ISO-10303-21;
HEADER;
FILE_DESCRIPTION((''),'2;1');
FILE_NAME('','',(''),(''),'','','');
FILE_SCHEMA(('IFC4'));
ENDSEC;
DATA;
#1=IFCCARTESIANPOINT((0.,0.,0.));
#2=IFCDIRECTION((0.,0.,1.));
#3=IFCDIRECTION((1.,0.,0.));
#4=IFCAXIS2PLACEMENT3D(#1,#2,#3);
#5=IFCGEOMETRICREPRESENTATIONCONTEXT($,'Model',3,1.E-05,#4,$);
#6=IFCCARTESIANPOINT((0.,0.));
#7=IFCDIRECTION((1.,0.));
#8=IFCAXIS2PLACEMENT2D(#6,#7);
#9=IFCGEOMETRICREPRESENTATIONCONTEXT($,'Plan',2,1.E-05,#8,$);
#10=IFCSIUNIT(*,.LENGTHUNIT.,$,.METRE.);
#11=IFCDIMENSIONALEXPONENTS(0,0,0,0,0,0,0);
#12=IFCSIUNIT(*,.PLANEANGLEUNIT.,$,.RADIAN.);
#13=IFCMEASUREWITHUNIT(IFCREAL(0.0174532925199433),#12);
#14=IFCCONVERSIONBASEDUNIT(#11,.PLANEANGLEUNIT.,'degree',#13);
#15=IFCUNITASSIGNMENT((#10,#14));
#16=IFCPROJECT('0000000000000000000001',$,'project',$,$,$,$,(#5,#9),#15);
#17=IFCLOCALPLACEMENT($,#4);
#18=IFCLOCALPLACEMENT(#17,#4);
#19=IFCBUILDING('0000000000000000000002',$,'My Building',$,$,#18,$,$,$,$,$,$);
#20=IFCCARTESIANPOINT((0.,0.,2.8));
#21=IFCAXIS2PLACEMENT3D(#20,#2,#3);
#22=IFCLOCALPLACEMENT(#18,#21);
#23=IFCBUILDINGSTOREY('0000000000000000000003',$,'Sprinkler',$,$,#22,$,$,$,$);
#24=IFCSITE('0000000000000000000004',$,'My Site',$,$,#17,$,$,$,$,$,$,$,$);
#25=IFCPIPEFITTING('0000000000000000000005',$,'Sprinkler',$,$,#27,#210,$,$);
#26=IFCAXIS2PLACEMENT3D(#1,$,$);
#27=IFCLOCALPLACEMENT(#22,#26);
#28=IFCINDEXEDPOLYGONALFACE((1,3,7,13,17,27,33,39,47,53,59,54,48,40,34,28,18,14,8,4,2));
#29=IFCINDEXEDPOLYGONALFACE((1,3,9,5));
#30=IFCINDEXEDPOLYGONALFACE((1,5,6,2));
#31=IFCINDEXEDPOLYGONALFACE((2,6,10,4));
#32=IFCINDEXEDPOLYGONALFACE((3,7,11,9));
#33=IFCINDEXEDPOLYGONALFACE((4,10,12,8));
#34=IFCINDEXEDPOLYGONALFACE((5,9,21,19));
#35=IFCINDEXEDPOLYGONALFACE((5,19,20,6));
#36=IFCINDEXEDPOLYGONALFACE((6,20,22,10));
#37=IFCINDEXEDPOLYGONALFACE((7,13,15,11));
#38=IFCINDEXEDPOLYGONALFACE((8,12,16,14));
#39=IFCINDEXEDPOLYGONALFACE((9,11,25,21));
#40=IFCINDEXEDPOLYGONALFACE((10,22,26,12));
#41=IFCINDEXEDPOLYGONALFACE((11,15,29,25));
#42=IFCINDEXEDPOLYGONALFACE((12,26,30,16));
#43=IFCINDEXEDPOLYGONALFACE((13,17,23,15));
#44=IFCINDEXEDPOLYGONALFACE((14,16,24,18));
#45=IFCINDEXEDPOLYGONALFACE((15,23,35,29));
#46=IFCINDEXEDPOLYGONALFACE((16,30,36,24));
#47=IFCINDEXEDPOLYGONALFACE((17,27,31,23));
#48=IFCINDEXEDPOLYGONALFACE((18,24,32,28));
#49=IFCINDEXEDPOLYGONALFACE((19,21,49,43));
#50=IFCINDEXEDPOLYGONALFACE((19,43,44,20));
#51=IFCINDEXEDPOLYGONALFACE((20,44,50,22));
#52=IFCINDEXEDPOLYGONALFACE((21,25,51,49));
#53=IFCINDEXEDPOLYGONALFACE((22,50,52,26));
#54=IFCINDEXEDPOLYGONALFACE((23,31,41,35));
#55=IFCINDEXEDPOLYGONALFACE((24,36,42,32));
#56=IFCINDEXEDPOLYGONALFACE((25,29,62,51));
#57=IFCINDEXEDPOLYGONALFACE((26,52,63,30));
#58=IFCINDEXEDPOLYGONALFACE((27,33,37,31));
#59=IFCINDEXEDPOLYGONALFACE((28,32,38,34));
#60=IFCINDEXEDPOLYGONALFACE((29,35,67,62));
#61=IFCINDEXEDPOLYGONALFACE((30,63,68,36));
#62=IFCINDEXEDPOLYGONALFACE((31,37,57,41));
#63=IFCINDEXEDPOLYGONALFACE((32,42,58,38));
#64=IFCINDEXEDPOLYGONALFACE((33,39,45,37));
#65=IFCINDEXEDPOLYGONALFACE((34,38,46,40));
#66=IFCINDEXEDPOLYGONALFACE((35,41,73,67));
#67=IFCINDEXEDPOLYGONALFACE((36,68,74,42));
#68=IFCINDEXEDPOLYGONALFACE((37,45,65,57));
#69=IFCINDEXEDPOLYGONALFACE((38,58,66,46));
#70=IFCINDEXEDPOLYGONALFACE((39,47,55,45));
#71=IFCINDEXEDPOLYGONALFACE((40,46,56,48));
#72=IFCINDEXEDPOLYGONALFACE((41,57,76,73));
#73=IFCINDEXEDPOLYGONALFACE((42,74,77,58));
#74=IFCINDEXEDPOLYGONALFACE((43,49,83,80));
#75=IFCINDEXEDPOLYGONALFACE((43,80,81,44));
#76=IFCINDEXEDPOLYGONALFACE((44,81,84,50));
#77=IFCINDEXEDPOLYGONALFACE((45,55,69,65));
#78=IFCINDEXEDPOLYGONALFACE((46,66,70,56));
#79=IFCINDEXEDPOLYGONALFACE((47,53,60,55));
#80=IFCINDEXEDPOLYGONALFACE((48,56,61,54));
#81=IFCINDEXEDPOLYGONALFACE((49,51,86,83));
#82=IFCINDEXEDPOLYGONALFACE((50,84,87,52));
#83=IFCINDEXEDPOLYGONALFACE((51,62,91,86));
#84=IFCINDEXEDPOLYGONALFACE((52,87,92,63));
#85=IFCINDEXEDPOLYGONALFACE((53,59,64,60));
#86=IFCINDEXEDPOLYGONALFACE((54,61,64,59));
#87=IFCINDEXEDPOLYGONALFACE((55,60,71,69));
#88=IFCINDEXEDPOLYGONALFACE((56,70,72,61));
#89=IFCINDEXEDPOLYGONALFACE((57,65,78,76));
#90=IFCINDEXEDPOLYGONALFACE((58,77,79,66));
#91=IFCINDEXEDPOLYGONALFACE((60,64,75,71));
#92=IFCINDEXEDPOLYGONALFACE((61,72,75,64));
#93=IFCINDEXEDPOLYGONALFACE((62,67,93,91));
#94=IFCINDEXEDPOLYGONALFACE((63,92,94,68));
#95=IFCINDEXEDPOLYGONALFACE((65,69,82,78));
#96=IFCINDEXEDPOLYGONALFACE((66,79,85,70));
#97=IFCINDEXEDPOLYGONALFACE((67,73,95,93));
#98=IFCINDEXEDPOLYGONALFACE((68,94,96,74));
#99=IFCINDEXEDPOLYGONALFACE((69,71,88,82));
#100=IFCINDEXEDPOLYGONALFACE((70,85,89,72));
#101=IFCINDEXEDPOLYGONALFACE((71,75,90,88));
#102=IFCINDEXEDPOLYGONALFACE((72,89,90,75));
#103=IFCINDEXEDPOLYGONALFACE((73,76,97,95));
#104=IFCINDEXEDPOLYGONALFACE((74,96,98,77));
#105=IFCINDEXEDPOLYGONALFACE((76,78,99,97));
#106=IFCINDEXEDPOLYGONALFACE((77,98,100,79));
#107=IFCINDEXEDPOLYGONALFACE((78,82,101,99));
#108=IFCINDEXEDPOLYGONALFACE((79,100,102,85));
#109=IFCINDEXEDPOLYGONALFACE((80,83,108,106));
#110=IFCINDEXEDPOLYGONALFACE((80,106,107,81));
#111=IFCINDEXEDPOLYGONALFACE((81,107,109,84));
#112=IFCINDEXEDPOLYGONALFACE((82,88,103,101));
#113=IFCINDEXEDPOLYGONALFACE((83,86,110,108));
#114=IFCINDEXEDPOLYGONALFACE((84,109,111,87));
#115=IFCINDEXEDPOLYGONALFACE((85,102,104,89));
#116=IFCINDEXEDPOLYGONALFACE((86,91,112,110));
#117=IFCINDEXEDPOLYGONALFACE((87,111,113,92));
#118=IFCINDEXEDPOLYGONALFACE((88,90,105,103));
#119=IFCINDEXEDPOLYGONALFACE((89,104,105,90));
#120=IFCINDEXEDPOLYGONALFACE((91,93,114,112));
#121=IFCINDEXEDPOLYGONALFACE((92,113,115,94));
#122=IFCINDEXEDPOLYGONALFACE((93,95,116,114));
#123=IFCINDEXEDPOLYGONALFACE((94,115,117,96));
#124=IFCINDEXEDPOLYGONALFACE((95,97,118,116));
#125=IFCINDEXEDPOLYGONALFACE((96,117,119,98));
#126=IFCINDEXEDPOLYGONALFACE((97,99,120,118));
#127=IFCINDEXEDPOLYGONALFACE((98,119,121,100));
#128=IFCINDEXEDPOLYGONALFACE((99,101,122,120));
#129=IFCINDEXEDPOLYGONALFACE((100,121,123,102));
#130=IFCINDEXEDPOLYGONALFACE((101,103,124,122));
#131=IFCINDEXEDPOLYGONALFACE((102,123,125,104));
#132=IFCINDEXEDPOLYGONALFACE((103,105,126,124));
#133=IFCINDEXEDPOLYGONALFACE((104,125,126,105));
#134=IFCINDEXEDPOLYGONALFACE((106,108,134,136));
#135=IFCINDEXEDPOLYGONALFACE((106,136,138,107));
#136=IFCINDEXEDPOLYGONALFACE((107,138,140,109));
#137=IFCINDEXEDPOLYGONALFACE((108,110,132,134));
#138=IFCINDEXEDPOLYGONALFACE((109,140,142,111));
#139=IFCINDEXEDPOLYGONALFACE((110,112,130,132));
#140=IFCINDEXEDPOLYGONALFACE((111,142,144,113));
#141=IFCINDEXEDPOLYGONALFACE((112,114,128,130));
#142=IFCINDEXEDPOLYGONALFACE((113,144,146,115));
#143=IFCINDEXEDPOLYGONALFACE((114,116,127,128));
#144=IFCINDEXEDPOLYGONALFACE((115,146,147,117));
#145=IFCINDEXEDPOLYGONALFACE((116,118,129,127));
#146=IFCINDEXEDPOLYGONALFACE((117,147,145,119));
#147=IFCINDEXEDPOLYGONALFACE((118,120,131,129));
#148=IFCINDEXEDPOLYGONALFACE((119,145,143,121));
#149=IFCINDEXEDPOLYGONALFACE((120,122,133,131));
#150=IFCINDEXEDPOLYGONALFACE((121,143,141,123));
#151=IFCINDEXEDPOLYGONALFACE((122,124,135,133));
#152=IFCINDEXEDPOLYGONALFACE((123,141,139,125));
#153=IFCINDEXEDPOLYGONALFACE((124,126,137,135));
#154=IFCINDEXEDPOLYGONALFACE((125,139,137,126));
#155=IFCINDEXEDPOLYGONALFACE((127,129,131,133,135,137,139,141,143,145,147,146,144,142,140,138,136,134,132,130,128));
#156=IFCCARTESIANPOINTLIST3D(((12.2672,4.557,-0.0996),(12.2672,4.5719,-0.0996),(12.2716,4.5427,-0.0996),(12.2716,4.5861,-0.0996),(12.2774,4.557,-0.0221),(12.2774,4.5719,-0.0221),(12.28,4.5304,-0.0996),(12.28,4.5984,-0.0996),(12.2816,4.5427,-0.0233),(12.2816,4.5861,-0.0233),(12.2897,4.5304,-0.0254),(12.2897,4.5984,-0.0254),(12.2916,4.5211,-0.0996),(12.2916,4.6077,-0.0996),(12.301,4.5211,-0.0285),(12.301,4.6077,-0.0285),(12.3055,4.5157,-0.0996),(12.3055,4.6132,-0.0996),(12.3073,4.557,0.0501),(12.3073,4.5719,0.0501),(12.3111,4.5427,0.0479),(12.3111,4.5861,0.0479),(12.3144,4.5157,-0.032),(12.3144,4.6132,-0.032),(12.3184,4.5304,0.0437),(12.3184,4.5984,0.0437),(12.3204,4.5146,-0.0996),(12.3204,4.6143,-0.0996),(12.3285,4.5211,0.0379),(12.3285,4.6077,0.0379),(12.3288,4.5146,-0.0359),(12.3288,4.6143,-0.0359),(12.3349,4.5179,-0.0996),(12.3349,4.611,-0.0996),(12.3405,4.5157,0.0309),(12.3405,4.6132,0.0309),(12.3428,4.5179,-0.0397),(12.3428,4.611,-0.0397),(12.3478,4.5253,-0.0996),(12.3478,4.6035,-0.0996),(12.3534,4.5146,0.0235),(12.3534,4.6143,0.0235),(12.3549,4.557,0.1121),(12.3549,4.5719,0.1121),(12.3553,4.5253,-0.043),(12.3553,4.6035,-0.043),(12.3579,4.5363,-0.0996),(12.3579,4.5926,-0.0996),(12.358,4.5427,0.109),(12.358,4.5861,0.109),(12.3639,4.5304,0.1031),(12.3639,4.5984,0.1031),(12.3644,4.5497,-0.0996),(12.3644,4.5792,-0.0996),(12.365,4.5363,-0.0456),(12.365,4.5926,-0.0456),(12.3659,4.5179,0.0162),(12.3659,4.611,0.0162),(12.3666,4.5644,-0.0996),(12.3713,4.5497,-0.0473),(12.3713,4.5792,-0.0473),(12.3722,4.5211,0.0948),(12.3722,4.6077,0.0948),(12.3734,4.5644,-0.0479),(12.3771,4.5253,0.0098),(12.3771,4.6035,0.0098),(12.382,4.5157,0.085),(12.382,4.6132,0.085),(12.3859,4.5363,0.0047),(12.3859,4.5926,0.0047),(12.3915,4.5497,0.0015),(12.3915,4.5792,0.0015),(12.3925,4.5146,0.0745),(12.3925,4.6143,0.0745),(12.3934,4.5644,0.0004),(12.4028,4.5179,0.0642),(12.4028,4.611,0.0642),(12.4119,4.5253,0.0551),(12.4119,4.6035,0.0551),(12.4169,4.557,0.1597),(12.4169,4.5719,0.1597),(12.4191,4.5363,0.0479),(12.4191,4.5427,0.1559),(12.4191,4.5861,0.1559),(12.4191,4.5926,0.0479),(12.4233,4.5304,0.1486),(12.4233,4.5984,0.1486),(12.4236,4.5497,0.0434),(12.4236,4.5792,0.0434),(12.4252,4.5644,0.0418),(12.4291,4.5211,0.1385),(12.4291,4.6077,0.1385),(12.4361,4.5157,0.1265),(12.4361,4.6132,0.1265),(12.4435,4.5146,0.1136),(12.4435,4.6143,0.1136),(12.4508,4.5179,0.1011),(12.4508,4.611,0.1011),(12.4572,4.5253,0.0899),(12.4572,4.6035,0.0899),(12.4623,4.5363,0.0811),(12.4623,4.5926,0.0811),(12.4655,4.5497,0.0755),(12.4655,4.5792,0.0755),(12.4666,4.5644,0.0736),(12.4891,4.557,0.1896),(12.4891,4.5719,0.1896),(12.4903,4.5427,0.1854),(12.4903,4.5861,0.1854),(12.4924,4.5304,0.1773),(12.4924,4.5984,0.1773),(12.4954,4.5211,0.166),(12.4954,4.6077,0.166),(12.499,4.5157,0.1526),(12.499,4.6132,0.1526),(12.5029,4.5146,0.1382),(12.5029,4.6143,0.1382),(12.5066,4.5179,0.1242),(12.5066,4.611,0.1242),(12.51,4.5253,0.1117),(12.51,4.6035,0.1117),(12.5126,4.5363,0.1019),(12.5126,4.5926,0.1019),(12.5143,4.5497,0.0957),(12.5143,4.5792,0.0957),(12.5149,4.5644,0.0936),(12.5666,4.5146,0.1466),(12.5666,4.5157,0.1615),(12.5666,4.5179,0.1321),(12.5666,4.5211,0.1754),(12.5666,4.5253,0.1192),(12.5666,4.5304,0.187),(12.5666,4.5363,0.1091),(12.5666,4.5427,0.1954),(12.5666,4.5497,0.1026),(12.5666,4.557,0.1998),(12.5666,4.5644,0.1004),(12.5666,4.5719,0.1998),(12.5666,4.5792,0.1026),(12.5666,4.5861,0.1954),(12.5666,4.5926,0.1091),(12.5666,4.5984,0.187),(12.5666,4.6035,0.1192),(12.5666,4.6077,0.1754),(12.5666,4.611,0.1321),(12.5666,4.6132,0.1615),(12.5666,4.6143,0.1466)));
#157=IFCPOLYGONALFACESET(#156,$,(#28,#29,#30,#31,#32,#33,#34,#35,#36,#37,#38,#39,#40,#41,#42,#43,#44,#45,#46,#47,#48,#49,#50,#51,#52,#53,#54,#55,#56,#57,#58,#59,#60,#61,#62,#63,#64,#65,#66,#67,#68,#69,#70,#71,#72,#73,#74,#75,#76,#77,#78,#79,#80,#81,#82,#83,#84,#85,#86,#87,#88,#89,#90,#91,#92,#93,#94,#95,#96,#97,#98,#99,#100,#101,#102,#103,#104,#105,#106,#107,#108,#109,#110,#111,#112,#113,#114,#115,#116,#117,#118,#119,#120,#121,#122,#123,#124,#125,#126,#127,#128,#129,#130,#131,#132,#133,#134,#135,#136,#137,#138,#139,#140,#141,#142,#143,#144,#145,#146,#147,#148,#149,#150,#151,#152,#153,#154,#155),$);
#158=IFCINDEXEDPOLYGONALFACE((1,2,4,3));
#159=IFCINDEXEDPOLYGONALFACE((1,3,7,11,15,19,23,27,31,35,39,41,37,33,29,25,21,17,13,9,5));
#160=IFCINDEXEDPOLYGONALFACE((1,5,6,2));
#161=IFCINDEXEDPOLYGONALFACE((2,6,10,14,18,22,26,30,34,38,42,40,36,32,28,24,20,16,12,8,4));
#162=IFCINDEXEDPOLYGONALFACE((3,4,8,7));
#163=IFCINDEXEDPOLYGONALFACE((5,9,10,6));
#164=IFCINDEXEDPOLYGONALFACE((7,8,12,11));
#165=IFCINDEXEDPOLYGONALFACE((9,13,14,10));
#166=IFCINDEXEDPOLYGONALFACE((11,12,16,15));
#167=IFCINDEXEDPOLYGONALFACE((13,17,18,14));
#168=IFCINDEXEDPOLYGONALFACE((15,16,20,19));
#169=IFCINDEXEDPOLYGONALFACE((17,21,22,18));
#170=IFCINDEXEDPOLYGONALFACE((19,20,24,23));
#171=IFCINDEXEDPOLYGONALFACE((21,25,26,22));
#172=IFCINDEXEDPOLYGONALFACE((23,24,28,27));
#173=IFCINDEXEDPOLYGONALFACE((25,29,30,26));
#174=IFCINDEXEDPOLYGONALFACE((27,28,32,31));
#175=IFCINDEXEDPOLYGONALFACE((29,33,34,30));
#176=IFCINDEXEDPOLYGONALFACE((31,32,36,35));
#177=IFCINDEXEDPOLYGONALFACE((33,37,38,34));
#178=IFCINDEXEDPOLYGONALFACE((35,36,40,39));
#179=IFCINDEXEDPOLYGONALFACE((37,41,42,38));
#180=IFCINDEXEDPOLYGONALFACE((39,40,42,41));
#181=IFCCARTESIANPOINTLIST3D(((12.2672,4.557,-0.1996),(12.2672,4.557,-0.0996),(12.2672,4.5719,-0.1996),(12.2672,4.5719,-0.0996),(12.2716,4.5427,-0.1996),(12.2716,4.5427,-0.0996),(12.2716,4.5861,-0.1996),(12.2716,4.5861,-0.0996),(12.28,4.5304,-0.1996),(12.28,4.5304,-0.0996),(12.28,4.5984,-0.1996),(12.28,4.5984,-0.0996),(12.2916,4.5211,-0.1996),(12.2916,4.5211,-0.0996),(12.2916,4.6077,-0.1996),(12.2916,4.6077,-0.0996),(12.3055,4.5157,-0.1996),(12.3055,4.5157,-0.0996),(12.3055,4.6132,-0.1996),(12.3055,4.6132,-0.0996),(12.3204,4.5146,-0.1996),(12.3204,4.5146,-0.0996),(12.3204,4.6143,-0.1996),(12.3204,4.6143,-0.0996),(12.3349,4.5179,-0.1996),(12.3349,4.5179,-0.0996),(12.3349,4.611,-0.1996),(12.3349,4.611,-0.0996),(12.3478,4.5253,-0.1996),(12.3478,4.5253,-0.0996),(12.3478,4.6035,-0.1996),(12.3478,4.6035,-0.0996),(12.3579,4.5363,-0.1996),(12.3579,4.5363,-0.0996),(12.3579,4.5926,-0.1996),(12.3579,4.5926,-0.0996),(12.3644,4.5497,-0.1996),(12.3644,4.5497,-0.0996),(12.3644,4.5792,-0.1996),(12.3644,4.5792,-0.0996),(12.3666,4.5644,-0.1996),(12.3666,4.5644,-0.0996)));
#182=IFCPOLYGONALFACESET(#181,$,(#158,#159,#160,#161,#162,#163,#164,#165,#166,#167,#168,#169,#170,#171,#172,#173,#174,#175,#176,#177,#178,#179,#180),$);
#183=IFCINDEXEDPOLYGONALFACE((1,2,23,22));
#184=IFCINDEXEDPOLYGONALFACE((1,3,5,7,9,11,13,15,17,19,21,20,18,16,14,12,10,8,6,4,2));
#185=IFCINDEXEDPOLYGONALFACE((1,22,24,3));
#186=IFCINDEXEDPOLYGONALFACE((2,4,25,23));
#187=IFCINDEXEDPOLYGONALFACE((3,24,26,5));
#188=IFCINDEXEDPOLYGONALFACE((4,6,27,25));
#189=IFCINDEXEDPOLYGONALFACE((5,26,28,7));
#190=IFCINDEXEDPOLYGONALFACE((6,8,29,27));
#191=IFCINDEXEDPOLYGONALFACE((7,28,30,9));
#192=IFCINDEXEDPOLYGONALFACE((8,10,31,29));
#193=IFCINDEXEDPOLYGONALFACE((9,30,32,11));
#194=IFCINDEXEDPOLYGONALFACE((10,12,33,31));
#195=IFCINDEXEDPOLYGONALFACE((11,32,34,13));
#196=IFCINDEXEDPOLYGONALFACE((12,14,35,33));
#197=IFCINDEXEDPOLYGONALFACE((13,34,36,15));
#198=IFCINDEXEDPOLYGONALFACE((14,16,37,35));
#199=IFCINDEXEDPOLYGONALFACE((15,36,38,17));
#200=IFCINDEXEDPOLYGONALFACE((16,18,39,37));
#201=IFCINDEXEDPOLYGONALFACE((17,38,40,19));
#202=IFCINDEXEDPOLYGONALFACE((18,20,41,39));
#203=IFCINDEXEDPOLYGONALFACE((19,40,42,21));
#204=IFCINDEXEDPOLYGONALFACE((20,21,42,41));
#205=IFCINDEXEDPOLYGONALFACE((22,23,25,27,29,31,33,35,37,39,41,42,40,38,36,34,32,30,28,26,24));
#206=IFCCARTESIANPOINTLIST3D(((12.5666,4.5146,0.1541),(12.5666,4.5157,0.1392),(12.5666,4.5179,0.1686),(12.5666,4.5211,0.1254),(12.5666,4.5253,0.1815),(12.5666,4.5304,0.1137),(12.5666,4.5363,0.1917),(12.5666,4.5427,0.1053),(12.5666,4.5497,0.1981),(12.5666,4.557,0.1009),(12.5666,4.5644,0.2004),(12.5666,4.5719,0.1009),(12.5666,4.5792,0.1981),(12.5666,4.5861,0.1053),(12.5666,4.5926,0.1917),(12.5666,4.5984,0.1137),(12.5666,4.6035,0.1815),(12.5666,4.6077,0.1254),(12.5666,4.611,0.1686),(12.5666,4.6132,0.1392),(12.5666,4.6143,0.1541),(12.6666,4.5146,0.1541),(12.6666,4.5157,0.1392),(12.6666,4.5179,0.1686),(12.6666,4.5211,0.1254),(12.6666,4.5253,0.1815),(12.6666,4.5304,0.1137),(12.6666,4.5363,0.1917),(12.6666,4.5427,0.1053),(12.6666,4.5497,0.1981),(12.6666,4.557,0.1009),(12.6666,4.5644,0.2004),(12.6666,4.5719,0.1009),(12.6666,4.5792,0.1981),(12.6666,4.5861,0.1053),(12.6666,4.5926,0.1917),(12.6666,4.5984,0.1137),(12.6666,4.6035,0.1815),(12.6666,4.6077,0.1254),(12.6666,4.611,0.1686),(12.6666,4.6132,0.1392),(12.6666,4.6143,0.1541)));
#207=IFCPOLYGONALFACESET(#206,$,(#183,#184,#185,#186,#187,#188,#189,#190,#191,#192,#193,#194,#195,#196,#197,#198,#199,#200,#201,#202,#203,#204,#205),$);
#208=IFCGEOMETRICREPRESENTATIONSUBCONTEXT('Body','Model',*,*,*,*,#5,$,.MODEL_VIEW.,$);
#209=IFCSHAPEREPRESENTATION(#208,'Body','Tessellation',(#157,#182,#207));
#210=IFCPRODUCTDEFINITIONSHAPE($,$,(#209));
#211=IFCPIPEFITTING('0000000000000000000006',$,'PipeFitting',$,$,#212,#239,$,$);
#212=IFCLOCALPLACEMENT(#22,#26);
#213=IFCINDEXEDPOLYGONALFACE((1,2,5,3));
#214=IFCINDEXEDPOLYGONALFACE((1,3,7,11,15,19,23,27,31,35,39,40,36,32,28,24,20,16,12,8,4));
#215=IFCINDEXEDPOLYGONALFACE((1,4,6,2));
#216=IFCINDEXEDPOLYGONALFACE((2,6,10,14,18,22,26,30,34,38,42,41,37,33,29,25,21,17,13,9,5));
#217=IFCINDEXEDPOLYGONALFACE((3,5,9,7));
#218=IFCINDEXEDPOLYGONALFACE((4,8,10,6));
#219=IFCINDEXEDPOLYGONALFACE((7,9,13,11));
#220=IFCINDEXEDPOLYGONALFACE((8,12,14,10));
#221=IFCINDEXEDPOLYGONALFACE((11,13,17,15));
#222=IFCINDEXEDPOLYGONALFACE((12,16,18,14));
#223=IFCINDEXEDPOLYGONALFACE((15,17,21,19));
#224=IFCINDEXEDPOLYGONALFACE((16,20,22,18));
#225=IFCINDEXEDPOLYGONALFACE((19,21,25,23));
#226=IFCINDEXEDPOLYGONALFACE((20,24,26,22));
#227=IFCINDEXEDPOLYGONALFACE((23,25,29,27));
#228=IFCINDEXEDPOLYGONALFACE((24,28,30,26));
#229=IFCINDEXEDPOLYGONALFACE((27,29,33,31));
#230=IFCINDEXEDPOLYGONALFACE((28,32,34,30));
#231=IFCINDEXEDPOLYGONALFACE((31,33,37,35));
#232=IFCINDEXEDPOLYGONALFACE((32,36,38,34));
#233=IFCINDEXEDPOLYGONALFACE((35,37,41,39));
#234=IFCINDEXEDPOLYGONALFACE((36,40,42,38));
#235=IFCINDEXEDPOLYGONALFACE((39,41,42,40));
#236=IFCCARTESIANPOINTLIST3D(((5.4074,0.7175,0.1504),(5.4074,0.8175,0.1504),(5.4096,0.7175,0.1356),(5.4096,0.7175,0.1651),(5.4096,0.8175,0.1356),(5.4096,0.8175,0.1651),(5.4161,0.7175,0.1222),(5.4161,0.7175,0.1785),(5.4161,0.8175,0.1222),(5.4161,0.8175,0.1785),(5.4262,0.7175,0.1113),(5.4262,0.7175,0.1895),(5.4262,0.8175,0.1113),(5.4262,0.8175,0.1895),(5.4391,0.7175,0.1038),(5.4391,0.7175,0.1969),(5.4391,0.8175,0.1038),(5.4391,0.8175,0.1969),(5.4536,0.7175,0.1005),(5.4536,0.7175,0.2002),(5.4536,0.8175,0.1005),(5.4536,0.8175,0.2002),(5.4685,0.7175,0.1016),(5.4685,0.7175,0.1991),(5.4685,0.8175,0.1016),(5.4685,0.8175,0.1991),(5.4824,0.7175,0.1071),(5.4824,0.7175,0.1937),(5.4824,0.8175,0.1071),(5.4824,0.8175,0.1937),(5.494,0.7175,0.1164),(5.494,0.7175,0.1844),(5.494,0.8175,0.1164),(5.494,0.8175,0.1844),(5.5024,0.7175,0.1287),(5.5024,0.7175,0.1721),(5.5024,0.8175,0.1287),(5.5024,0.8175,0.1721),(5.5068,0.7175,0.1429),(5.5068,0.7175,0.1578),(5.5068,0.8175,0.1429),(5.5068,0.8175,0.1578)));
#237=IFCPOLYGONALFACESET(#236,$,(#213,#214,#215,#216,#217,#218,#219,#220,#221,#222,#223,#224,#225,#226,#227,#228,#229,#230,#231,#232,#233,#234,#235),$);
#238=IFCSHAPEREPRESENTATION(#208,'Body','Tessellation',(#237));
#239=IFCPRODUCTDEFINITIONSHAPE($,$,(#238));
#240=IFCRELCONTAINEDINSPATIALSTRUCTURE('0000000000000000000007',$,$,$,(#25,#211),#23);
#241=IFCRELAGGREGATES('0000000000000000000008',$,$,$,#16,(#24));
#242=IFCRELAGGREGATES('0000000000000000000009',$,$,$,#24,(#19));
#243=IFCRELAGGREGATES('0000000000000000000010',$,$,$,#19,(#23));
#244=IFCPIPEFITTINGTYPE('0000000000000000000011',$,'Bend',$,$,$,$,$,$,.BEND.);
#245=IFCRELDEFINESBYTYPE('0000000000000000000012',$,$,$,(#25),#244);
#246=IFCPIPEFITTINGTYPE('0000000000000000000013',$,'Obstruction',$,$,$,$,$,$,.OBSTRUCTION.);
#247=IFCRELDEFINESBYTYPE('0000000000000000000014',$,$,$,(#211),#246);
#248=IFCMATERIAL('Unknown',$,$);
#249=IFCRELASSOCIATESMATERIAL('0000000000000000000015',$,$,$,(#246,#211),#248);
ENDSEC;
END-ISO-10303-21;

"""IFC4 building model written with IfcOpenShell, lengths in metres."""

from ifc_helpers import new_model, entity, si_unit, converted_unit, frame, origin_with_axes, origin_2d_with_axis, place, context, subcontext, project, spatial, circle, extrude, source, transform, mapped, material, material_profile, profile_set, profile_usage, type_object, type_shapes, element, save


model = new_model("IFC4")

# Units and contexts
model_context = context("Model", 3, precision=1e-05, world=origin_with_axes())
plan_context = context("Plan", 2, precision=1e-05, world=origin_2d_with_axis())
body_context = subcontext(model_context, "Body", "Model", "MODEL_VIEW")
ifc_project = project(units=[si_unit("LENGTHUNIT", "METRE"), converted_unit("PLANEANGLEUNIT", "degree", entity("IfcReal", 0.0174532925199433), si_unit("PLANEANGLEUNIT", "RADIAN"), dimensions=[0, 0, 0, 0, 0, 0, 0])], contexts=[model_context, plan_context])

# Site, building, storey
site_placement = place(None, origin_with_axes())
site = spatial("IfcSite", under=ifc_project, at=site_placement, Name="My Site")
building_placement = place(site_placement, origin_with_axes())
building = spatial("IfcBuilding", under=site, at=building_placement, Name="My Building")
storey_placement = place(building_placement, frame((0.0, 0.0, 2.8), z_axis=(0.0, 0.0, 1.0), x_axis=(1.0, 0.0, 0.0)))
storey = spatial("IfcBuildingStorey", under=building, at=storey_placement, Name="Sprinkler")

# Shared definitions
ifc_material = material(Name="Unknown")

# Pipe fittings
pipe_fitting_type_1 = type_object("IfcPipeFittingType", Name="Bend", PredefinedType="BEND")
shared_shape = source(origin_with_axes(), body_context, "Body", "SolidModel", [
    entity("IfcSweptDiskSolid", entity("IfcIndexedPolyCurve", entity("IfcCartesianPointList3D", [[0.0, 0.0, 0.1], [0.0732, 0.0, 0.2768], [0.25, 0.0, 0.35]]), [entity("IfcArcIndex", [1, 2, 3])]), 0.05),
    extrude(circle(Radius=0.05), origin_with_axes(), (0.0, 0.0, 1.0), 0.1),
    extrude(circle(Radius=0.05), frame((0.25, 0.0, 0.35), z_axis=(1.0, 0.0, 0.000001), x_axis=(-0.000001, 0.0, 1.0)), (0.0, 0.0, 1.0), 0.1),
])
type_shapes(pipe_fitting_type_1, [shared_shape])
for number, where, z_axis, x_axis, name in (
    (1, (12.3166, 4.5644, -0.1996), (0.000008, 0.0, 1.0), (1.0, 0.000001, -0.000008), "Sprinkler"),
):
    element("IfcPipeFitting", number, at=place(storey_placement, frame(where, z_axis=z_axis, x_axis=x_axis)), inside=storey, type_object=pipe_fitting_type_1, Name=name, context=body_context, shape_type="MappedRepresentation", body=[
        mapped(shared_shape, transform((0.0, 0.0, 0.0), x_axis=(1.0, 0.0, 0.0), y_axis=(0.0, 1.0, 0.0), z_axis=(0.0, 0.0, 1.0), scale=1.0)),
    ])
ifc_material_profile_1 = material_profile(ifc_material, circle(Radius=0.05))
ifc_profile_set_1 = profile_set([ifc_material_profile_1])
ifc_profile_usage_1 = profile_usage(ifc_profile_set_1, cardinal=5)
pipe_fitting_type_2 = type_object("IfcPipeFittingType", Name="Obstruction", PredefinedType="OBSTRUCTION", material=ifc_profile_set_1)
pipe_fitting_1_placement = place(storey_placement, frame((5.4574, 0.7175, 0.1504), z_axis=(0.0, 1.0, 0.0), x_axis=(-1.0, 0.0, 0.0)))
element("IfcPipeFitting", 2, at=pipe_fitting_1_placement, inside=storey, type_object=pipe_fitting_type_2, material=ifc_profile_usage_1, Name="PipeFitting", context=body_context, shape_type="SweptSolid", body=[
    extrude(circle(Radius=0.05), origin_with_axes(), (0.0, 0.0, 1.0), 0.1),
])

save(model, "model.ifc")
